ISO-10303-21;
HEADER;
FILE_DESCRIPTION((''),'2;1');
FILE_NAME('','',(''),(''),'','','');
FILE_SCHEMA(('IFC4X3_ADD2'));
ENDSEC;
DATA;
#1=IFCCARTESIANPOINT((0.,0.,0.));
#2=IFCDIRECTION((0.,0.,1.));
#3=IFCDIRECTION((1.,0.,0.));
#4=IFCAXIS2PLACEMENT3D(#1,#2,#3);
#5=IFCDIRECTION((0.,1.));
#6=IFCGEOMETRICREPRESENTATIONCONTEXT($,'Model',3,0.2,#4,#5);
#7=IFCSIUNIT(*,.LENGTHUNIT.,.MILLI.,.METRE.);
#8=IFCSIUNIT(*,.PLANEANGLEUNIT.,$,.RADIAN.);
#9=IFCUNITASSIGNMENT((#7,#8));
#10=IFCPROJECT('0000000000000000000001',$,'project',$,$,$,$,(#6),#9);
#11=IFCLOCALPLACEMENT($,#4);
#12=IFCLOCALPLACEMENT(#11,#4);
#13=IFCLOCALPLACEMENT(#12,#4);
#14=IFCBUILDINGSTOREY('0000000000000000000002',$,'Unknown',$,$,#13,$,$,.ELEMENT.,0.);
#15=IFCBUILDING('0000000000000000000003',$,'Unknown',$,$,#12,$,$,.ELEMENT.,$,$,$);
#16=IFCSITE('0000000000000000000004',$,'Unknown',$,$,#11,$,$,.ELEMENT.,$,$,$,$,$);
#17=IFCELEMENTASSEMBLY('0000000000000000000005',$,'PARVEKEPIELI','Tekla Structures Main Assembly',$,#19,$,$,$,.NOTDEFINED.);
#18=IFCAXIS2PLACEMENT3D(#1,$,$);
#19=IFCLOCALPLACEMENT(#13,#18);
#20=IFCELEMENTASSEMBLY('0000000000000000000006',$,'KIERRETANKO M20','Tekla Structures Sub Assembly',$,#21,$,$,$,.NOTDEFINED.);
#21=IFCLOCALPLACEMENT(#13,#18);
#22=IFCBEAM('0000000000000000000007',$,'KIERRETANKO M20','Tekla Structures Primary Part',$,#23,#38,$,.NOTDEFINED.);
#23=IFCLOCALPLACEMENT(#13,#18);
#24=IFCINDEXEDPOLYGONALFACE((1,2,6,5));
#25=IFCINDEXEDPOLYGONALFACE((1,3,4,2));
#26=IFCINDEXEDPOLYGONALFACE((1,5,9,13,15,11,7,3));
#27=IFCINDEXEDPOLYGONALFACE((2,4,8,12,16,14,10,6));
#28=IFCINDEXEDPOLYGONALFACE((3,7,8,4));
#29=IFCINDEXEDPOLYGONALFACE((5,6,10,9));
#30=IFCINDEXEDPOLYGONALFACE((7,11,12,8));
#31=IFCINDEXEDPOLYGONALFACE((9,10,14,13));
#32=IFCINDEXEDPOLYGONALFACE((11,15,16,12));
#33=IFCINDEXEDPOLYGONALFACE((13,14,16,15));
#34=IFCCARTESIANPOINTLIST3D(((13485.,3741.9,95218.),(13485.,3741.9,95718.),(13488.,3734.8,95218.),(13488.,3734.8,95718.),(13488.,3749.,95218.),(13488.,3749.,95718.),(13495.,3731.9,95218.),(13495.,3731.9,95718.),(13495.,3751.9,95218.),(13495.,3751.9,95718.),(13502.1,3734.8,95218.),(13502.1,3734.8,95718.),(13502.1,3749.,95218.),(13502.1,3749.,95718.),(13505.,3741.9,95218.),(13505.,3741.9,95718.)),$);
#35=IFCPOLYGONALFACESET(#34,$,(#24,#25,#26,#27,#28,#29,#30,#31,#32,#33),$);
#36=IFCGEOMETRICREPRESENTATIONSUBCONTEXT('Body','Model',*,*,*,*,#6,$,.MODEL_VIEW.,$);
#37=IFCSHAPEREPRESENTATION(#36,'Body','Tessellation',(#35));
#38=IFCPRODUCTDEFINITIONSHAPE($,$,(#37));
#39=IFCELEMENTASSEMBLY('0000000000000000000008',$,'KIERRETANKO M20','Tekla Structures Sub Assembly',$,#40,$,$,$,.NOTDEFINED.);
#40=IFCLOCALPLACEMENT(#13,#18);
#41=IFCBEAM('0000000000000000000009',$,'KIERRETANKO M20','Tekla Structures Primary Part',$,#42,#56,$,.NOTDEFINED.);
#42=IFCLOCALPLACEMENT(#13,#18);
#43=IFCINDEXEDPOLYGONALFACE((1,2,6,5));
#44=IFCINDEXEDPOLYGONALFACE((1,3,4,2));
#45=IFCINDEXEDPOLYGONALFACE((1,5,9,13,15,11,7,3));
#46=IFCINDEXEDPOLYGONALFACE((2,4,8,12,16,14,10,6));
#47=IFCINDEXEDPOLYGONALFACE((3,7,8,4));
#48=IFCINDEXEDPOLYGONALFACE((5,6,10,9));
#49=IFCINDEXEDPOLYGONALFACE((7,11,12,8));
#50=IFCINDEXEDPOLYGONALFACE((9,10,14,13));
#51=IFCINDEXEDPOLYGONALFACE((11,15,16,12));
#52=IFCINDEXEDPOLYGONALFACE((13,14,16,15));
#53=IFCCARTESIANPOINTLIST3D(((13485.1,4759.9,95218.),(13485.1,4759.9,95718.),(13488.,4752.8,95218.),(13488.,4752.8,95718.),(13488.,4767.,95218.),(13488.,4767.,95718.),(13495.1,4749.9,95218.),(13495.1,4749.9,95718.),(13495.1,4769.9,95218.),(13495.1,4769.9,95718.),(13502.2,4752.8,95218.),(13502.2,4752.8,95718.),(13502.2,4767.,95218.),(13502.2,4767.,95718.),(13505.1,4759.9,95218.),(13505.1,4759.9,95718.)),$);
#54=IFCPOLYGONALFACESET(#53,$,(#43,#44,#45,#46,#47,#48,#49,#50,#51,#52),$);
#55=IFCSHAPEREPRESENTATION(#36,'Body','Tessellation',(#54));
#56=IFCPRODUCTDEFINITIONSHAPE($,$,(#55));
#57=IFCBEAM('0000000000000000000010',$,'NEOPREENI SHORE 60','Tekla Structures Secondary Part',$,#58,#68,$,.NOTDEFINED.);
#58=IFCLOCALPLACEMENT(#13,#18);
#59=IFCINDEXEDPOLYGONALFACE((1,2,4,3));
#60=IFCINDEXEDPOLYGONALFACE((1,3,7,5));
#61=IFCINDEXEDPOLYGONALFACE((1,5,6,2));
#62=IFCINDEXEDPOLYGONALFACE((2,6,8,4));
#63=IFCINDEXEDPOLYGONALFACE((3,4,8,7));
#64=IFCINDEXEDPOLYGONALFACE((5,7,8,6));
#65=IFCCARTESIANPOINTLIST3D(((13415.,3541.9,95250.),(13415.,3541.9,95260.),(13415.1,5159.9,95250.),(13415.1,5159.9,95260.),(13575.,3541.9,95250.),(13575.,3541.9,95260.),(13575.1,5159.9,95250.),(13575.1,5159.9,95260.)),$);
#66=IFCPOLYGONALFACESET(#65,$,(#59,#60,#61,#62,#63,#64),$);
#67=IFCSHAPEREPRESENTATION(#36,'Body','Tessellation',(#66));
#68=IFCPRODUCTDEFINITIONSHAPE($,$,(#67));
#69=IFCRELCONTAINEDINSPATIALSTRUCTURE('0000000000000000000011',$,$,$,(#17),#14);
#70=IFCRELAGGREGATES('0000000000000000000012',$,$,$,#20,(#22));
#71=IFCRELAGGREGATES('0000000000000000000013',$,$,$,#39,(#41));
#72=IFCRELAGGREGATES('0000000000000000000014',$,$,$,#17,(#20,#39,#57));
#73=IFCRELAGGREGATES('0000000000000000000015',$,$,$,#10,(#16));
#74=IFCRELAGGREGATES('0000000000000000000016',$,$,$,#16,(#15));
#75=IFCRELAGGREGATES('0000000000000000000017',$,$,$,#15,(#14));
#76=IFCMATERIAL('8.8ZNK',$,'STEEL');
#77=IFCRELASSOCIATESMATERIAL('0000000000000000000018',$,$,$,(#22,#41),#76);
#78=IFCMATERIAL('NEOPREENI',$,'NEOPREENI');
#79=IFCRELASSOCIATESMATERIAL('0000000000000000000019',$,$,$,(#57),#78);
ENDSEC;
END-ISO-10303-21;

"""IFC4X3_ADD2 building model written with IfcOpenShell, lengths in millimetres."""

from ifc_helpers import new_model, si_unit, direction, frame, origin_with_axes, place, context, subcontext, project, spatial, line, indexed_curve, outline, extrude, material, element, aggregate, save


model = new_model("IFC4X3_ADD2")

# Units and contexts
model_context = context("Model", 3, precision=0.2, world=origin_with_axes(), true_north=direction((0.0, 1.0)))
body_context = subcontext(model_context, "Body", "Model", "MODEL_VIEW")
ifc_project = project(units=[si_unit("LENGTHUNIT", "METRE", prefix="MILLI"), si_unit("PLANEANGLEUNIT", "RADIAN")], contexts=[model_context])

# Site, building, storey
site_placement = place(None, origin_with_axes())
site = spatial("IfcSite", under=ifc_project, at=site_placement, Name="Unknown", CompositionType="ELEMENT")
building_placement = place(site_placement, origin_with_axes())
building = spatial("IfcBuilding", under=site, at=building_placement, Name="Unknown", CompositionType="ELEMENT")
storey_placement = place(building_placement, origin_with_axes())
storey = spatial("IfcBuildingStorey", under=building, at=storey_placement, Name="Unknown", CompositionType="ELEMENT", Elevation=0.0)

# Element assembly
assembly_1_placement = place(storey_placement, frame((13495.0, 3341.9, 94125.0), z_axis=(1.0, -0.000056, 0.0), x_axis=(0.000056, 1.0, 0.0)))
assembly_1 = element("IfcElementAssembly", 1, at=assembly_1_placement, inside=storey, Name="PARVEKEPIELI", Description="Tekla Structures Main Assembly", PredefinedType="NOTDEFINED")

# Shared definitions
ifc_material_1 = material(Name="8.8ZNK", Category="STEEL")

# Shared definitions
ifc_material_2 = material(Name="NEOPREENI", Category="NEOPREENI")

# Element assemblies, beams
assembly_2_placement = place(assembly_1_placement, frame((400.0, 1593.0, 0.0), z_axis=(1.0, 0.0, -0.000004), x_axis=(0.0, -1.0, 0.0)))
assembly_2 = element("IfcElementAssembly", 2, at=assembly_2_placement, Name="KIERRETANKO M20", Description="Tekla Structures Sub Assembly", PredefinedType="NOTDEFINED")
beam_1_placement = place(assembly_2_placement, origin_with_axes())
beam_1 = element("IfcBeam", 3, at=beam_1_placement, material=ifc_material_1, Name="KIERRETANKO M20", Description="Tekla Structures Primary Part", PredefinedType="NOTDEFINED", context=body_context, shape_type="SolidModel", body=[
    extrude(outline(indexed_curve([(10.0, 0.0), (7.1, 7.1), (0.0, 10.0), (-7.1, 7.1), (-10.0, 0.0), (-7.1, -7.1), (0.0, -10.0), (7.1, -7.1)], segments=[line(1, 2, 3, 4, 5, 6, 7, 8, 1)])), frame((0.0, 0.0, 0.0), z_axis=(-1.0, 0.0, 0.0), x_axis=(0.0, 0.0, 1.0)), (0.0, 0.0, -1.0), 500.0),
])
aggregate(assembly_2, [beam_1])
assembly_3_placement = place(assembly_1_placement, frame((1418.0, 1593.0, 0.0), z_axis=(1.0, 0.0, -0.000004), x_axis=(0.0, -1.0, 0.0)))
assembly_3 = element("IfcElementAssembly", 4, at=assembly_3_placement, Name="KIERRETANKO M20", Description="Tekla Structures Sub Assembly", PredefinedType="NOTDEFINED")
beam_2_placement = place(assembly_3_placement, origin_with_axes())
beam_2 = element("IfcBeam", 5, at=beam_2_placement, material=ifc_material_1, Name="KIERRETANKO M20", Description="Tekla Structures Primary Part", PredefinedType="NOTDEFINED", context=body_context, shape_type="SolidModel", body=[
    extrude(outline(indexed_curve([(10.0, 0.0), (7.1, 7.1), (0.0, 10.0), (-7.1, 7.1), (-10.0, 0.0), (-7.1, -7.1), (0.0, -10.0), (7.1, -7.1)], segments=[line(1, 2, 3, 4, 5, 6, 7, 8, 1)])), frame((0.0, 0.0, 0.0), z_axis=(-1.0, 0.0, 0.0), x_axis=(0.0, 0.0, 1.0)), (0.0, 0.0, -1.0), 500.0),
])
aggregate(assembly_3, [beam_2])

# Beam
beam_3_placement = place(assembly_1_placement, frame((200.0, 1130.0, 0.0), z_axis=(0.0, 0.0, 1.0), x_axis=(1.0, 0.0, 0.0)))
beam_3 = element("IfcBeam", 6, at=beam_3_placement, material=ifc_material_2, Name="NEOPREENI SHORE 60", Description="Tekla Structures Secondary Part", PredefinedType="NOTDEFINED", context=body_context, shape_type="SolidModel", body=[
    extrude(outline(indexed_curve([(-80.0, -5.0), (80.0, -5.0), (80.0, 5.0), (-80.0, 5.0)], segments=[line(1, 2, 3, 4, 1)])), frame((0.0, 0.0, 0.0), z_axis=(-1.0, 0.0, 0.0), x_axis=(0.0, 0.0, 1.0)), (0.0, 0.0, -1.0), 1618.0),
])
aggregate(assembly_1, [assembly_2, assembly_3, beam_3])

save(model, "model.ifc")
